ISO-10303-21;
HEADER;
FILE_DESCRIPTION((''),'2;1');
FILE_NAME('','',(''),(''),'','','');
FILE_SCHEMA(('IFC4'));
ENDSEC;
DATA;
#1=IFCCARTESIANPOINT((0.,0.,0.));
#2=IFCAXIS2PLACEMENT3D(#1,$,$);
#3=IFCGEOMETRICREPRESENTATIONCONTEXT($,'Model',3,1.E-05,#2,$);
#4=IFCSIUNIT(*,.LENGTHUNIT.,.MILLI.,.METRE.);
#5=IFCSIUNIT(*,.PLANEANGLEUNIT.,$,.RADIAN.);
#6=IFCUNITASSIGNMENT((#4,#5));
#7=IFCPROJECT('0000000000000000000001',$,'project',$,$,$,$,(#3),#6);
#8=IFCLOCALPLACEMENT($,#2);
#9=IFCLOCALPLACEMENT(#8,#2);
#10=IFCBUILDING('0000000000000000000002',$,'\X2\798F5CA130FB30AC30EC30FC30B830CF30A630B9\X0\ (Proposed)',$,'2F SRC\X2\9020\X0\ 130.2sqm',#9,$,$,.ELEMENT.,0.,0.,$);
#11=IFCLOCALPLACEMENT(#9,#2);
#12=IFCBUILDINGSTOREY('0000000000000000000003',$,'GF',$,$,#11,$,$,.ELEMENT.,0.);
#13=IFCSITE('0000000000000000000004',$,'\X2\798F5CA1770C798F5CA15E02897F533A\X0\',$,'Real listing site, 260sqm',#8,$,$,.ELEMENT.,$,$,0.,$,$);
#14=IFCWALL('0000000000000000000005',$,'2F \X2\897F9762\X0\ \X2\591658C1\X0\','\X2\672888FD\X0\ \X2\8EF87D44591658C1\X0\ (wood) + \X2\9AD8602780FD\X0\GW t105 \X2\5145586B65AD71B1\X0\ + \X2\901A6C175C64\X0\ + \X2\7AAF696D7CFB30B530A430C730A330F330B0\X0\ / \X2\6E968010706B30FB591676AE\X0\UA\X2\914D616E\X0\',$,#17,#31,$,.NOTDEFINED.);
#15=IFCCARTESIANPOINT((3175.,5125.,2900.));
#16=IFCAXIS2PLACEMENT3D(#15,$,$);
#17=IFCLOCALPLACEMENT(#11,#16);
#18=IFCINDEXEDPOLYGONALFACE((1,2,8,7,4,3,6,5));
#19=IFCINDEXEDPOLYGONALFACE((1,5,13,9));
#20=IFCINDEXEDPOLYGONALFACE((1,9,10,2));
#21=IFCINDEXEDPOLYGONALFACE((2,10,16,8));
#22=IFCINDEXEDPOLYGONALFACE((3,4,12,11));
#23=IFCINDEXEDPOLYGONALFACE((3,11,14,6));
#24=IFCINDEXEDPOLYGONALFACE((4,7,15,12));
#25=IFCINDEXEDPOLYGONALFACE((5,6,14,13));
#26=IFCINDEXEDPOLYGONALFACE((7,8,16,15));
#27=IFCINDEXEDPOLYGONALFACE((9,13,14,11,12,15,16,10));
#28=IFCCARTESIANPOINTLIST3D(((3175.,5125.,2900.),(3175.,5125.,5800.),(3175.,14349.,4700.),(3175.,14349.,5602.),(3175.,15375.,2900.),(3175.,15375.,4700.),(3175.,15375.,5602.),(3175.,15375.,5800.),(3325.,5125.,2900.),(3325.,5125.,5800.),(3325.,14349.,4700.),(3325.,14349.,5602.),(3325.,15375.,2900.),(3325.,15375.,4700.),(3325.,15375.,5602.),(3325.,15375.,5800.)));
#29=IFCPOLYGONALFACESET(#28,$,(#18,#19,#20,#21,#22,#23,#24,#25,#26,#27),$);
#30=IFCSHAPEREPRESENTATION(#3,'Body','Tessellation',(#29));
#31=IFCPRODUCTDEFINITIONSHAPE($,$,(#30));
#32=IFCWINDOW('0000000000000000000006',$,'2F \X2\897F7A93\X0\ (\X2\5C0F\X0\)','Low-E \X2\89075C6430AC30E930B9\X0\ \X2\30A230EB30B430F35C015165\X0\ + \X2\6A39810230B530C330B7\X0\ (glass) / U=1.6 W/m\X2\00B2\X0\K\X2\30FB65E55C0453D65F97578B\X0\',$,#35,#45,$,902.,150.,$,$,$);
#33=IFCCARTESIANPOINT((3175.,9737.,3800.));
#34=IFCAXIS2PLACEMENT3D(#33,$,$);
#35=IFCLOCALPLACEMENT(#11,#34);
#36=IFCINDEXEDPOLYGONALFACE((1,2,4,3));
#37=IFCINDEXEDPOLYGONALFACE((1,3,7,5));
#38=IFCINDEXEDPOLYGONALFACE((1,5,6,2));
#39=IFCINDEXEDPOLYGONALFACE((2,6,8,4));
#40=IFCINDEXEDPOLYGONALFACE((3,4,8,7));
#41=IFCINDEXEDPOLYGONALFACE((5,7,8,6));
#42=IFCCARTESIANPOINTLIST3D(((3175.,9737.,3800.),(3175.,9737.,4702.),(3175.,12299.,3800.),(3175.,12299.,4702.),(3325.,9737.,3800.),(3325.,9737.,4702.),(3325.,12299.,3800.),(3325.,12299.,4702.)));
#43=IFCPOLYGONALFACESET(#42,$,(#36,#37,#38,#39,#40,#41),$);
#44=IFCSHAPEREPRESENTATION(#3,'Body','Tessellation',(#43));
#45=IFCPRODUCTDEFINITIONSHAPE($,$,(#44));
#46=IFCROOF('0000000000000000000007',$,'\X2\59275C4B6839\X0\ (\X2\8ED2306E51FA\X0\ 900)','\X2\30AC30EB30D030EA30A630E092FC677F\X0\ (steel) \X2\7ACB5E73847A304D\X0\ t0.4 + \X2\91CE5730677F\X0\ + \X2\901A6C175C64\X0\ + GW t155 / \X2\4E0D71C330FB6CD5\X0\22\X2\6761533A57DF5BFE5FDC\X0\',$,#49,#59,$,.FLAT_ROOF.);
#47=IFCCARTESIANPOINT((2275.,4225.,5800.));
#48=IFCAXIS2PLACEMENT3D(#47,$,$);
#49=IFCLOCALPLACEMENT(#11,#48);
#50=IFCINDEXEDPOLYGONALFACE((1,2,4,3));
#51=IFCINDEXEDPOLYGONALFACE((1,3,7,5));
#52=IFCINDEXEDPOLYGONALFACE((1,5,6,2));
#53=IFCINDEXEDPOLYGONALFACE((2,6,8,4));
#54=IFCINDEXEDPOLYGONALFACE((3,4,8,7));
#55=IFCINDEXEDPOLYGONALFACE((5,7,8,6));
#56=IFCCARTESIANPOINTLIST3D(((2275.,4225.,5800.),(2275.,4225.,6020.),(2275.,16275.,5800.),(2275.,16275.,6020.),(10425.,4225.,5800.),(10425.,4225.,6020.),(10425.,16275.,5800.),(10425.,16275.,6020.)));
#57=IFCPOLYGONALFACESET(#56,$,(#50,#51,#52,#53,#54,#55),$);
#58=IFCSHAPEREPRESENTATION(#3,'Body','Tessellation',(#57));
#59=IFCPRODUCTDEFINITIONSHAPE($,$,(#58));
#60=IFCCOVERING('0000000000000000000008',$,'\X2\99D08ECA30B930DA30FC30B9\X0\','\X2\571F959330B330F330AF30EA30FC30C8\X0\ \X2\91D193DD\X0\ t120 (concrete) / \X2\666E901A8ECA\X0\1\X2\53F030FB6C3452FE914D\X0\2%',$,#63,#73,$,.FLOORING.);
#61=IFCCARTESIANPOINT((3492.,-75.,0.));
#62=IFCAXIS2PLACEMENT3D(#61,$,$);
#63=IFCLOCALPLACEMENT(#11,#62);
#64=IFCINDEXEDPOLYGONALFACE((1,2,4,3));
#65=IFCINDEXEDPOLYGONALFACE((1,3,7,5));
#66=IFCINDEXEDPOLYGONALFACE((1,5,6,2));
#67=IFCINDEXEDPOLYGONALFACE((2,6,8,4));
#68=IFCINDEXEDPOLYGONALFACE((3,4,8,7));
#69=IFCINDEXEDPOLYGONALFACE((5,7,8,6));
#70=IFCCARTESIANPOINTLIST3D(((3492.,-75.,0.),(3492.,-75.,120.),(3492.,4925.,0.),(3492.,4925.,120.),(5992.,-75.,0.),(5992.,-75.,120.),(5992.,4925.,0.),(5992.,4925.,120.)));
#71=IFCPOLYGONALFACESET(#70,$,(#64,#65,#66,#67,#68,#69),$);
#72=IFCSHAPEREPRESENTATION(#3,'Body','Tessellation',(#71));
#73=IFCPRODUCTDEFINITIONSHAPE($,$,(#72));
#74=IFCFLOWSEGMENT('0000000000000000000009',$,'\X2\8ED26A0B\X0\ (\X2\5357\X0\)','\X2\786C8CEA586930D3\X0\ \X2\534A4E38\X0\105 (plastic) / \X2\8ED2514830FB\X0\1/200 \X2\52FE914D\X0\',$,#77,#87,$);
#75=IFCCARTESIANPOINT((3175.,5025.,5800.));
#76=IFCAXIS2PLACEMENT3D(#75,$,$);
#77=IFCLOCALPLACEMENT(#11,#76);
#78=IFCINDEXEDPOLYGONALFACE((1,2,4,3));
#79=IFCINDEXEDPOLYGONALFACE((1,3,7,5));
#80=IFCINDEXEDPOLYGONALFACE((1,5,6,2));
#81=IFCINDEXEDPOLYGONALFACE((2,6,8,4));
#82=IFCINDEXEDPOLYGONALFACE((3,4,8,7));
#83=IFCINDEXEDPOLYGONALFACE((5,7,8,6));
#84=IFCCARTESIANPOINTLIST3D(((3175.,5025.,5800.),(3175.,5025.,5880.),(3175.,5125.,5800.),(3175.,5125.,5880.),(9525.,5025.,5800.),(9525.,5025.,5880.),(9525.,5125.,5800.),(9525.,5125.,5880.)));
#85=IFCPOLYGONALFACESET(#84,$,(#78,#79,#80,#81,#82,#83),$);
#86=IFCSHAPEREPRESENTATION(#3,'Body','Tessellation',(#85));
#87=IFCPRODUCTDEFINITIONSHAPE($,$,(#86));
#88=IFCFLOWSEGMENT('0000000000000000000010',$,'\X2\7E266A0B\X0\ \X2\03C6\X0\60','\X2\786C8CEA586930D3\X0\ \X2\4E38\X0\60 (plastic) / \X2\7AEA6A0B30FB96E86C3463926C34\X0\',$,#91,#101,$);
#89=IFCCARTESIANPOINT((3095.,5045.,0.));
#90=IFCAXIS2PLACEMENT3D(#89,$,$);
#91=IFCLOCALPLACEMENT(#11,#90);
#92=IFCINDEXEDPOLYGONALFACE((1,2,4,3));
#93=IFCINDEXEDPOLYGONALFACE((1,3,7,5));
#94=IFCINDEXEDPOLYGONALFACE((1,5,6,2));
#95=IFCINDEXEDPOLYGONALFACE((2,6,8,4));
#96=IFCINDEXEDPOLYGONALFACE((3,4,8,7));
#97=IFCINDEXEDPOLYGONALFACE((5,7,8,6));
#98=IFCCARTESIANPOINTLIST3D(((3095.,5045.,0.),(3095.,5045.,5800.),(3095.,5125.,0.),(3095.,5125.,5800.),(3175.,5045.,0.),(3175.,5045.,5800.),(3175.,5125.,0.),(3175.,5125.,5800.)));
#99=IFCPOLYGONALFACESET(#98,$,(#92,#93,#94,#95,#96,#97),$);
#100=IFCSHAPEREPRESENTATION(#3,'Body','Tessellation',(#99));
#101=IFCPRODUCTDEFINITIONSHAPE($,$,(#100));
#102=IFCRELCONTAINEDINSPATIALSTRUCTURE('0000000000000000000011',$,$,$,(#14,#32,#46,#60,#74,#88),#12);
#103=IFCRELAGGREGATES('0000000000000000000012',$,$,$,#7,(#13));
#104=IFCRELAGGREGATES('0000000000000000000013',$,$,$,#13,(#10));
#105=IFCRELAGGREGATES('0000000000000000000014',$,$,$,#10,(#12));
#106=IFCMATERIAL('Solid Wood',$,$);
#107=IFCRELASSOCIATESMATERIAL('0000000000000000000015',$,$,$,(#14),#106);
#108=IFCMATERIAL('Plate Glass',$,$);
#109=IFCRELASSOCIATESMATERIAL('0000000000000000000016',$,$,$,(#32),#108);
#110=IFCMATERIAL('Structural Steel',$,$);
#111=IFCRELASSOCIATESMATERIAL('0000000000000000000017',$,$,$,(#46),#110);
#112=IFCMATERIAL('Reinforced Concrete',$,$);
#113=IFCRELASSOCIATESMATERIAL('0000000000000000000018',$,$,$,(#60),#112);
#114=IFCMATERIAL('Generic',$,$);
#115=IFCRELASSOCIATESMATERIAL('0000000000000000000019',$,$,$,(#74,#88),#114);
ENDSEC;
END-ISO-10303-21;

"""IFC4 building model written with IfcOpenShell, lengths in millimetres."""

from ifc_helpers import new_model, si_unit, frame, frame_2d, origin, place, context, project, spatial, rectangle, extrude, material, element, fill, save


model = new_model("IFC4")

# Units and contexts
model_context = context("Model", 3, precision=1e-05, world=origin())
ifc_project = project(units=[si_unit("LENGTHUNIT", "METRE", prefix="MILLI"), si_unit("PLANEANGLEUNIT", "RADIAN")], contexts=[model_context])

# Site, building, storey
site_placement = place(None, origin())
site = spatial("IfcSite", under=ifc_project, at=site_placement, Name="福岡県福岡市西区", ObjectType="Real listing site, 260sqm", CompositionType="ELEMENT", RefElevation=0.0)
building_placement = place(site_placement, origin())
building = spatial("IfcBuilding", under=site, at=building_placement, Name="福岡・ガレージハウス (Proposed)", ObjectType="2F SRC造 130.2sqm", CompositionType="ELEMENT", ElevationOfRefHeight=0.0, ElevationOfTerrain=0.0)
storey_placement = place(building_placement, origin())
storey = spatial("IfcBuildingStorey", under=building, at=storey_placement, Name="GF", CompositionType="ELEMENT", Elevation=0.0)

# Shared definitions
ifc_material_1 = material(Name="Solid Wood")

# Shared definitions
ifc_material_2 = material(Name="Reinforced Concrete")

# Shared definitions
ifc_material_3 = material(Name="Plate Glass")

# Wall, opening, window
wall_1_placement = place(storey_placement, frame((3175.0, 5125.0, 2900.0)))
wall_1 = element("IfcWall", 1, at=wall_1_placement, inside=storey, material=ifc_material_1, Name="2F 西面 外壁", Description="木製 軸組外壁 (wood) + 高性能GW t105 充填断熱 + 通気層 + 窯業系サイディング / 準耐火・外皮UA配慮", PredefinedType="NOTDEFINED", context=model_context, shape_type="SweptSolid", body=[
    extrude(rectangle(XDim=150.0, YDim=10250.0, at=frame_2d((75.0, 5125.0))), frame((3175.0, 5125.0, 2900.0)), (0.0, 0.0, 1.0), 2900.0),
])
opening_1_placement = place(storey_placement, frame((3175.0, 9737.0, 3800.0)))
opening_1 = element("IfcOpeningElement", 2, at=opening_1_placement, cuts=wall_1, PredefinedType="NOTDEFINED", context=model_context, shape_type="SweptSolid", body=[
    extrude(rectangle(XDim=150.0, YDim=2562.0, at=frame_2d((75.0, 1281.0))), frame((3175.0, 9737.0, 3800.0)), (0.0, 0.0, 1.0), 902.0),
])
window_1_placement = place(storey_placement, frame((3175.0, 9737.0, 3800.0)))
window_1 = element("IfcWindow", 3, at=window_1_placement, inside=storey, material=ifc_material_3, Name="2F 西窓 (小)", Description="Low-E 複層ガラス アルゴン封入 + 樹脂サッシ (glass) / U=1.6 W/m²K・日射取得型", OverallHeight=902.0, OverallWidth=150.0, context=model_context, shape_type="SweptSolid", body=[
    extrude(rectangle(XDim=150.0, YDim=2562.0, at=frame_2d((75.0, 1281.0))), frame((3175.0, 9737.0, 3800.0)), (0.0, 0.0, 1.0), 902.0),
])
fill(opening_1, window_1)

# Roof
ifc_material_4 = material(Name="Structural Steel")
roof_placement = place(storey_placement, frame((2275.0, 4225.0, 5800.0)))
element("IfcRoof", 4, at=roof_placement, inside=storey, material=ifc_material_4, Name="大屋根 (軒の出 900)", Description="ガルバリウム鋼板 (steel) 立平葺き t0.4 + 野地板 + 通気層 + GW t155 / 不燃・法22条区域対応", PredefinedType="FLAT_ROOF", context=model_context, shape_type="SweptSolid", body=[
    extrude(rectangle(XDim=8150.0, YDim=12050.0, at=frame_2d((4075.0, 6025.0))), frame((2275.0, 4225.0, 5800.0)), (0.0, 0.0, 1.0), 220.0),
])

# Covering
covering_placement = place(storey_placement, frame((3492.0, -75.0, 0.0)))
element("IfcCovering", 5, at=covering_placement, inside=storey, material=ifc_material_2, Name="駐車スペース", Description="土間コンクリート 金鏝 t120 (concrete) / 普通車1台・水勾配2%", PredefinedType="FLOORING", context=model_context, shape_type="SweptSolid", body=[
    extrude(rectangle(XDim=2500.0, YDim=5000.0, at=frame_2d((1250.0, 2500.0))), frame((3492.0, -75.0, 0.0)), (0.0, 0.0, 1.0), 120.0),
])

# Flow segments
ifc_material_5 = material(Name="Generic")
flow_segment_1_placement = place(storey_placement, frame((3175.0, 5025.0, 5800.0)))
element("IfcFlowSegment", 6, at=flow_segment_1_placement, inside=storey, material=ifc_material_5, Name="軒樋 (南)", Description="硬質塩ビ 半丸105 (plastic) / 軒先・1/200 勾配", context=model_context, shape_type="SweptSolid", body=[
    extrude(rectangle(XDim=6350.0, YDim=100.0, at=frame_2d((3175.0, 50.0))), frame((3175.0, 5025.0, 5800.0)), (0.0, 0.0, 1.0), 80.0),
])
flow_segment_2_placement = place(storey_placement, frame((3095.0, 5045.0, 0.0)))
element("IfcFlowSegment", 7, at=flow_segment_2_placement, inside=storey, material=ifc_material_5, Name="縦樋 φ60", Description="硬質塩ビ 丸60 (plastic) / 竪樋・雨水排水", context=model_context, shape_type="SweptSolid", body=[
    extrude(rectangle(XDim=80.0, YDim=80.0, at=frame_2d((40.0, 40.0))), frame((3095.0, 5045.0, 0.0)), (0.0, 0.0, 1.0), 5800.0),
])

save(model, "model.ifc")
